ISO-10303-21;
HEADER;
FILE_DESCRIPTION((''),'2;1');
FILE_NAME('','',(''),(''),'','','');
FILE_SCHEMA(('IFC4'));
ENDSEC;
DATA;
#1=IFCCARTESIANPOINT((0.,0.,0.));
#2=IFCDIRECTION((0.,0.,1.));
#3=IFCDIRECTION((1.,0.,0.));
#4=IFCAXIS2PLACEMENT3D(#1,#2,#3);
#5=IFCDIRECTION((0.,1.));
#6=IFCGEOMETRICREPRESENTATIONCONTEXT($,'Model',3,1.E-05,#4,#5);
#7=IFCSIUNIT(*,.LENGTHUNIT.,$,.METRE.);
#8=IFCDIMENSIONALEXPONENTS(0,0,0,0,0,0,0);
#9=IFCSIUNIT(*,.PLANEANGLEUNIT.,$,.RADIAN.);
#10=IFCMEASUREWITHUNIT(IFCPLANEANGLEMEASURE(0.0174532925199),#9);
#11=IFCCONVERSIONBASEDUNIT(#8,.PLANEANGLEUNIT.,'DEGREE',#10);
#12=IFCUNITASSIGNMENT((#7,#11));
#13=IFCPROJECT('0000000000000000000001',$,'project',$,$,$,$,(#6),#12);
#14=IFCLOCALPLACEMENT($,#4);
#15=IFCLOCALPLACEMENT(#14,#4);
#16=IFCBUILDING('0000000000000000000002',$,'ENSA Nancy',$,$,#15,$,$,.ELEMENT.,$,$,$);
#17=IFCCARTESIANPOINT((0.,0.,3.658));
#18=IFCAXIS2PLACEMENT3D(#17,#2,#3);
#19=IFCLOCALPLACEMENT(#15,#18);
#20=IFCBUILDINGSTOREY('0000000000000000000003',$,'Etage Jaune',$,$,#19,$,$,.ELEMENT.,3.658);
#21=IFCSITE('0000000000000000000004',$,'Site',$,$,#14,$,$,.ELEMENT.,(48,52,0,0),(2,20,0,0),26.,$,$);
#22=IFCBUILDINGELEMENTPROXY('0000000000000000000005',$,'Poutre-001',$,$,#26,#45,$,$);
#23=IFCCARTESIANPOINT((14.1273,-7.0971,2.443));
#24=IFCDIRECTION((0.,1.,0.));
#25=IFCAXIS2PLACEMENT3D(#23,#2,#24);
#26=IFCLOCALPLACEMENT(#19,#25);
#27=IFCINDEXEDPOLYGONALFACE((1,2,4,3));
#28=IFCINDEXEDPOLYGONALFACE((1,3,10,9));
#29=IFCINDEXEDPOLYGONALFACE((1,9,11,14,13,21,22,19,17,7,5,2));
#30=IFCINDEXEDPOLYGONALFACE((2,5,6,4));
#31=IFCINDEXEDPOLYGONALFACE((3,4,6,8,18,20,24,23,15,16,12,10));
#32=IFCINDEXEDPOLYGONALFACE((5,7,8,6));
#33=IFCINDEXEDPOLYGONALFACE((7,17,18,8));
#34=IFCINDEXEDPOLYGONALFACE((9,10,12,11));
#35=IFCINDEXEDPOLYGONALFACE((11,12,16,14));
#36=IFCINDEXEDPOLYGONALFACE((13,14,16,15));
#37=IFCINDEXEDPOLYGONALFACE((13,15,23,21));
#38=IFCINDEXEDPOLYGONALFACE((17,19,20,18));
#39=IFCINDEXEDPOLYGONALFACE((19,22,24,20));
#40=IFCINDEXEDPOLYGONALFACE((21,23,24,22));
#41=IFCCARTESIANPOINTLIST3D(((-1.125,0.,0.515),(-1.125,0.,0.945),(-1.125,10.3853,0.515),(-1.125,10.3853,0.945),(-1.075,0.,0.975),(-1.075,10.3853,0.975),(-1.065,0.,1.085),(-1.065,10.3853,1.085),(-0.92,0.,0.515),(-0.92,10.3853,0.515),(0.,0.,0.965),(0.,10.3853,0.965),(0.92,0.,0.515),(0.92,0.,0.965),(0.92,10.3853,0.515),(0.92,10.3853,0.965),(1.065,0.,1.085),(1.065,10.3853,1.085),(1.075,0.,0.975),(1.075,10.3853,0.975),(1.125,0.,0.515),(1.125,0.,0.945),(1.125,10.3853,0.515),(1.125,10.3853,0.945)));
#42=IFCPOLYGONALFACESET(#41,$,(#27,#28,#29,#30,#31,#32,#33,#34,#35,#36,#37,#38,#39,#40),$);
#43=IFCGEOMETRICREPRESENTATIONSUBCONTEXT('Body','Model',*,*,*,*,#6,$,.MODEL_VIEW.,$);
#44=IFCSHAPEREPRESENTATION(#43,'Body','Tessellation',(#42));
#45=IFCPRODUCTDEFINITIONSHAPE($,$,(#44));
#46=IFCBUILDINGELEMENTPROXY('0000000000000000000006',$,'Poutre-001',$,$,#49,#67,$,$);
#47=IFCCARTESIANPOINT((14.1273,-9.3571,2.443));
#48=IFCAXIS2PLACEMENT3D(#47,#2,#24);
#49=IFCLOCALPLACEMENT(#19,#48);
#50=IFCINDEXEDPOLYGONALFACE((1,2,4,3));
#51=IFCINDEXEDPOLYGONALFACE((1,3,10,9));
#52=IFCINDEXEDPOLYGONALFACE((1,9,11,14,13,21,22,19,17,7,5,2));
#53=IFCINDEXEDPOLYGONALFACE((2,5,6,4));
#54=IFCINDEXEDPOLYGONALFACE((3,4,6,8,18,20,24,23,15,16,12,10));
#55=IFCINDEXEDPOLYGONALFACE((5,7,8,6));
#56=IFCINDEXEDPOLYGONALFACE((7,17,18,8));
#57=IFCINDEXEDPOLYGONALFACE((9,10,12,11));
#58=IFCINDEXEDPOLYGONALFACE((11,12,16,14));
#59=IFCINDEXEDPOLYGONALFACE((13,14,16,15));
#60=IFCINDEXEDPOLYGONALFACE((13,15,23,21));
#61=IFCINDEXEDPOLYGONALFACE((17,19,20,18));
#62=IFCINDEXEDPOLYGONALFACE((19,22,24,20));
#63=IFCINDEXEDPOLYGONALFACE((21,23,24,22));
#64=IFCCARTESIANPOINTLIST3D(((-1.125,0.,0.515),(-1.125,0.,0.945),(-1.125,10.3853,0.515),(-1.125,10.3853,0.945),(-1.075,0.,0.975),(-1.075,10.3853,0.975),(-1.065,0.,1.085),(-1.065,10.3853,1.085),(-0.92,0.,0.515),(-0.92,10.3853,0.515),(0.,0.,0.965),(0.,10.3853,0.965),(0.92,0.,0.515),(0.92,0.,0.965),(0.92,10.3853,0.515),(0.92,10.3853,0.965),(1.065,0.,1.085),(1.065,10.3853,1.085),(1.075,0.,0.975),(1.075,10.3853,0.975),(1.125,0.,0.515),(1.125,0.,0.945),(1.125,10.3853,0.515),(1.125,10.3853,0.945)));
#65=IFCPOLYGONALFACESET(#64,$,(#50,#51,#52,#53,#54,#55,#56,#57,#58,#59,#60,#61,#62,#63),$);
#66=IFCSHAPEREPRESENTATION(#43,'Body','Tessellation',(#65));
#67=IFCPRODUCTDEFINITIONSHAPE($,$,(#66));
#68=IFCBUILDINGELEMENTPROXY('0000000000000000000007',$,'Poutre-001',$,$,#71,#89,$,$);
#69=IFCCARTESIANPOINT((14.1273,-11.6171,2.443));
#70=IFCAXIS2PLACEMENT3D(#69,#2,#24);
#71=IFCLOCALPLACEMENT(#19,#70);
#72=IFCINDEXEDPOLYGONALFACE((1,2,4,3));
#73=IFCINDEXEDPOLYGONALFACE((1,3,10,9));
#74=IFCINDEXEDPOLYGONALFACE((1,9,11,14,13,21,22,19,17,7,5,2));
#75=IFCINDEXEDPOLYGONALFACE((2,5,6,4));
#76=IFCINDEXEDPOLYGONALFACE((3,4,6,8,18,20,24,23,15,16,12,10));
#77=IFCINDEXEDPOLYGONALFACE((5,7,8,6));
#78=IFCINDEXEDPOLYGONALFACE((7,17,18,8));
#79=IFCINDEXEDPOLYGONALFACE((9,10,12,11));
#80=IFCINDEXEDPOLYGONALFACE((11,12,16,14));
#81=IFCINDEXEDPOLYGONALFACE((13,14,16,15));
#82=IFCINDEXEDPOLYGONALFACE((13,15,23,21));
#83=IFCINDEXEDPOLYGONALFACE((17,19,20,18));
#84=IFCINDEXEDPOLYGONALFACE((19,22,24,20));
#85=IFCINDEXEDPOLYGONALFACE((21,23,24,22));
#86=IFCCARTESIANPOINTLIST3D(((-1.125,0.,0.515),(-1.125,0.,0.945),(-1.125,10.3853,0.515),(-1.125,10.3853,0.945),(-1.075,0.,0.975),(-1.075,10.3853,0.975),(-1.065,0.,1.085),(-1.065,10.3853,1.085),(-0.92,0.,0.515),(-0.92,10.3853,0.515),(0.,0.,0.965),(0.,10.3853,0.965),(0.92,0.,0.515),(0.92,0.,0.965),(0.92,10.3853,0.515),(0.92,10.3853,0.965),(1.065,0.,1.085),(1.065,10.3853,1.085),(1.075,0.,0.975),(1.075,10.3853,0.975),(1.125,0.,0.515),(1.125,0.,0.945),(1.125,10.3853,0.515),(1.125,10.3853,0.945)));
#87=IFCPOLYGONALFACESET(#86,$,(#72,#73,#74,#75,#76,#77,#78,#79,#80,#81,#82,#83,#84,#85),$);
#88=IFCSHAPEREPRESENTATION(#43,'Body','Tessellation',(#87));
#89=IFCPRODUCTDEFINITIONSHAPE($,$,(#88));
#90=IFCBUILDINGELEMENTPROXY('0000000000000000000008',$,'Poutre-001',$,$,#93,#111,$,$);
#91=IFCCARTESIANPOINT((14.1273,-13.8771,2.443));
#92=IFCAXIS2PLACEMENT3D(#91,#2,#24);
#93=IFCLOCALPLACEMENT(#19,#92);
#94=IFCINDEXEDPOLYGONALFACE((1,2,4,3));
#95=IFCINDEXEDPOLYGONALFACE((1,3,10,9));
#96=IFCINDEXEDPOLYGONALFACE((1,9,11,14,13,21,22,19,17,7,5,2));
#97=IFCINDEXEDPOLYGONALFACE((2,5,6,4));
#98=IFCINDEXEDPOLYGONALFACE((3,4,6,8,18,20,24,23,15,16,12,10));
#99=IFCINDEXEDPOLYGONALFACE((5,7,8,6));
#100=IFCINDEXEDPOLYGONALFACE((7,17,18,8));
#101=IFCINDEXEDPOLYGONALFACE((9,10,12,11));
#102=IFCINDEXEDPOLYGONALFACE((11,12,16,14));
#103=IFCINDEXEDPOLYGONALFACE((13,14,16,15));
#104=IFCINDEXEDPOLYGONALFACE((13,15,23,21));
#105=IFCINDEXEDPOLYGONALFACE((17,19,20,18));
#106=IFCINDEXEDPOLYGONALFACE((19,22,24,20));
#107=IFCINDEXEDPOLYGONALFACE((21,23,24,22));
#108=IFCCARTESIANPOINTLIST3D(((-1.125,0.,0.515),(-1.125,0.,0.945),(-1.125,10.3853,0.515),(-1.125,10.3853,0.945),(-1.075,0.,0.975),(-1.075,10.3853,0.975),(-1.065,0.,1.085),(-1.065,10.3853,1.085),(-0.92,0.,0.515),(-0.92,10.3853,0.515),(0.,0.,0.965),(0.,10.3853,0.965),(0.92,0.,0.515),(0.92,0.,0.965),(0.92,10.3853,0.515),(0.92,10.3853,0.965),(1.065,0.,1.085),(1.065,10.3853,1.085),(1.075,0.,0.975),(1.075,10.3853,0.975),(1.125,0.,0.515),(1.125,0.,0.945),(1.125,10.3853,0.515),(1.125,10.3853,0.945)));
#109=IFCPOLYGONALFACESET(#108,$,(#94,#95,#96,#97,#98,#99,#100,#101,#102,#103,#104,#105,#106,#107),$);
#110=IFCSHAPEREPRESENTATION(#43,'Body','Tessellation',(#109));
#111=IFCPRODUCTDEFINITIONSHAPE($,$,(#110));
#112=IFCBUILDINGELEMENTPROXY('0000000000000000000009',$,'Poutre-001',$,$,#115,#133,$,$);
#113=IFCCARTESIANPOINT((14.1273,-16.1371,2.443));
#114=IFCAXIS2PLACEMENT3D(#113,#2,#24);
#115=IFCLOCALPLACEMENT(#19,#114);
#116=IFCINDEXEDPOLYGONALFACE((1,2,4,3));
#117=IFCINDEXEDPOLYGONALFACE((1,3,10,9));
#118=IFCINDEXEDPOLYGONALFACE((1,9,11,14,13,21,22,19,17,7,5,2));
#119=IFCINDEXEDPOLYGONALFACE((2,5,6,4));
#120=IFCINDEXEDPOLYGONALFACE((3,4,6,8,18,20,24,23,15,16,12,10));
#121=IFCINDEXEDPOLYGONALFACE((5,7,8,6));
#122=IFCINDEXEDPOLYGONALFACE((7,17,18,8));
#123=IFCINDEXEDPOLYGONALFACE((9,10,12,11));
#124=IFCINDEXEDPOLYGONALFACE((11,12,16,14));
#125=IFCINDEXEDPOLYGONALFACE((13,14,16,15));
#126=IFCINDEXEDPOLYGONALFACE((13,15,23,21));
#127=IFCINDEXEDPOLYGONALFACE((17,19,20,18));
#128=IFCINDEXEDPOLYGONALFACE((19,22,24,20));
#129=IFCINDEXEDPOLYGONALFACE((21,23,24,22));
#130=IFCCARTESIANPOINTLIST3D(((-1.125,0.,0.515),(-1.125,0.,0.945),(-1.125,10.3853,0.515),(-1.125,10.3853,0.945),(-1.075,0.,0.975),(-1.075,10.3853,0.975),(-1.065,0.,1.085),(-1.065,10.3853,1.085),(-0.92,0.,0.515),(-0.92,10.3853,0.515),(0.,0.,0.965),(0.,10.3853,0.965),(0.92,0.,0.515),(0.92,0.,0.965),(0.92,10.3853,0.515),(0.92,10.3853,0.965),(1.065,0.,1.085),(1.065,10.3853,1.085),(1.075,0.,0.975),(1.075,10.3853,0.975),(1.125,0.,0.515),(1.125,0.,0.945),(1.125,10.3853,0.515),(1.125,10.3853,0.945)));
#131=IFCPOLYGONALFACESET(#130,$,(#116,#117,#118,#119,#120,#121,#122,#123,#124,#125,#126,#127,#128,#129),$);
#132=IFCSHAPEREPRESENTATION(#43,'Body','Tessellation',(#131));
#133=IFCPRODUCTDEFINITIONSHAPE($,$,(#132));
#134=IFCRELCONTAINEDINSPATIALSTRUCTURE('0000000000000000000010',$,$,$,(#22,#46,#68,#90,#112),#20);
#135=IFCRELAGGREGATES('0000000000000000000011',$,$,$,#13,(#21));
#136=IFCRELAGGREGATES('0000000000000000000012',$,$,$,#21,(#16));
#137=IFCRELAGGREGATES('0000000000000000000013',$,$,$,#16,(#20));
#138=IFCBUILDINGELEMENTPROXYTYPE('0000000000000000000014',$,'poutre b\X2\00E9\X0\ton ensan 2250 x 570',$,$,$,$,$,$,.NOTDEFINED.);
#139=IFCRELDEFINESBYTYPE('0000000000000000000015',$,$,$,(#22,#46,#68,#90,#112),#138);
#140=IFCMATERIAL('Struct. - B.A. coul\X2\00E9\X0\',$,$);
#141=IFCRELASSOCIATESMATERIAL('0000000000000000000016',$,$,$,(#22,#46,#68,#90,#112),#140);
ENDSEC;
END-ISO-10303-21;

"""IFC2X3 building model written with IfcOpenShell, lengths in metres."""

from ifc_helpers import new_model, entity, si_unit, converted_unit, direction, frame, origin_with_axes, place, context, subcontext, project, spatial, polyline, outline, extrude, material, type_object, element, save


model = new_model("IFC2X3")

# Units and contexts
model_context = context("Model", 3, precision=1e-05, world=origin_with_axes(), true_north=direction((0.0, 1.0)))
body_context = subcontext(model_context, "Body", "Model", "MODEL_VIEW")
ifc_project = project(units=[si_unit("LENGTHUNIT", "METRE"), converted_unit("PLANEANGLEUNIT", "DEGREE", entity("IfcPlaneAngleMeasure", 0.0174532925199), si_unit("PLANEANGLEUNIT", "RADIAN"), dimensions=[0, 0, 0, 0, 0, 0, 0])], contexts=[model_context])

# Site, building, storey
site_placement = place(None, origin_with_axes())
site = spatial("IfcSite", under=ifc_project, at=site_placement, Name="Site", CompositionType="ELEMENT", RefLatitude=(48, 52, 0, 0), RefLongitude=(2, 20, 0, 0), RefElevation=26.0)
building_placement = place(site_placement, origin_with_axes())
building = spatial("IfcBuilding", under=site, at=building_placement, Name="ENSA Nancy", CompositionType="ELEMENT")
storey_placement = place(building_placement, frame((0.0, 0.0, 3.658), z_axis=(0.0, 0.0, 1.0), x_axis=(1.0, 0.0, 0.0)))
storey = spatial("IfcBuildingStorey", under=building, at=storey_placement, Name="Etage Jaune", CompositionType="ELEMENT", Elevation=3.658)

# Building element proxies
ifc_material_1 = material(Name="Struct. - B.A. coulé")
building_element_proxy_type_1 = type_object("IfcBuildingElementProxyType", Name="poutre béton ensan 2250 x 570", PredefinedType="NOTDEFINED")
for number, where, z_axis, x_axis, name in (
    (1, (14.1273, -7.0971, 2.443), (0.0, 0.0, 1.0), (0.0, 1.0, 0.0), "Poutre-001"),
    (2, (14.1273, -9.3571, 2.443), (0.0, 0.0, 1.0), (0.0, 1.0, 0.0), "Poutre-001"),
    (3, (14.1273, -11.6171, 2.443), (0.0, 0.0, 1.0), (0.0, 1.0, 0.0), "Poutre-001"),
    (4, (14.1273, -13.8771, 2.443), (0.0, 0.0, 1.0), (0.0, 1.0, 0.0), "Poutre-001"),
    (5, (14.1273, -16.1371, 2.443), (0.0, 0.0, 1.0), (0.0, 1.0, 0.0), "Poutre-001"),
):
    element("IfcBuildingElementProxy", number, at=place(storey_placement, frame(where, z_axis=z_axis, x_axis=x_axis)), inside=storey, type_object=building_element_proxy_type_1, material=ifc_material_1, Name=name, context=body_context, shape_type="SweptSolid", body=[
        extrude(outline(polyline([(-1.065, 1.085), (-1.075, 0.975), (-1.125, 0.945), (-1.125, 0.515), (-0.92, 0.515), (0.0, 0.965), (0.92, 0.965), (0.92, 0.515), (1.125, 0.515), (1.125, 0.945), (1.075, 0.975), (1.065, 1.085), (-1.065, 1.085)])), frame((0.0, 10.3853, 0.0), z_axis=(0.0, -1.0, 0.0), x_axis=(1.0, 0.0, 0.0)), (0.0, 0.0, 1.0), 10.3853),
    ])

save(model, "model.ifc")
